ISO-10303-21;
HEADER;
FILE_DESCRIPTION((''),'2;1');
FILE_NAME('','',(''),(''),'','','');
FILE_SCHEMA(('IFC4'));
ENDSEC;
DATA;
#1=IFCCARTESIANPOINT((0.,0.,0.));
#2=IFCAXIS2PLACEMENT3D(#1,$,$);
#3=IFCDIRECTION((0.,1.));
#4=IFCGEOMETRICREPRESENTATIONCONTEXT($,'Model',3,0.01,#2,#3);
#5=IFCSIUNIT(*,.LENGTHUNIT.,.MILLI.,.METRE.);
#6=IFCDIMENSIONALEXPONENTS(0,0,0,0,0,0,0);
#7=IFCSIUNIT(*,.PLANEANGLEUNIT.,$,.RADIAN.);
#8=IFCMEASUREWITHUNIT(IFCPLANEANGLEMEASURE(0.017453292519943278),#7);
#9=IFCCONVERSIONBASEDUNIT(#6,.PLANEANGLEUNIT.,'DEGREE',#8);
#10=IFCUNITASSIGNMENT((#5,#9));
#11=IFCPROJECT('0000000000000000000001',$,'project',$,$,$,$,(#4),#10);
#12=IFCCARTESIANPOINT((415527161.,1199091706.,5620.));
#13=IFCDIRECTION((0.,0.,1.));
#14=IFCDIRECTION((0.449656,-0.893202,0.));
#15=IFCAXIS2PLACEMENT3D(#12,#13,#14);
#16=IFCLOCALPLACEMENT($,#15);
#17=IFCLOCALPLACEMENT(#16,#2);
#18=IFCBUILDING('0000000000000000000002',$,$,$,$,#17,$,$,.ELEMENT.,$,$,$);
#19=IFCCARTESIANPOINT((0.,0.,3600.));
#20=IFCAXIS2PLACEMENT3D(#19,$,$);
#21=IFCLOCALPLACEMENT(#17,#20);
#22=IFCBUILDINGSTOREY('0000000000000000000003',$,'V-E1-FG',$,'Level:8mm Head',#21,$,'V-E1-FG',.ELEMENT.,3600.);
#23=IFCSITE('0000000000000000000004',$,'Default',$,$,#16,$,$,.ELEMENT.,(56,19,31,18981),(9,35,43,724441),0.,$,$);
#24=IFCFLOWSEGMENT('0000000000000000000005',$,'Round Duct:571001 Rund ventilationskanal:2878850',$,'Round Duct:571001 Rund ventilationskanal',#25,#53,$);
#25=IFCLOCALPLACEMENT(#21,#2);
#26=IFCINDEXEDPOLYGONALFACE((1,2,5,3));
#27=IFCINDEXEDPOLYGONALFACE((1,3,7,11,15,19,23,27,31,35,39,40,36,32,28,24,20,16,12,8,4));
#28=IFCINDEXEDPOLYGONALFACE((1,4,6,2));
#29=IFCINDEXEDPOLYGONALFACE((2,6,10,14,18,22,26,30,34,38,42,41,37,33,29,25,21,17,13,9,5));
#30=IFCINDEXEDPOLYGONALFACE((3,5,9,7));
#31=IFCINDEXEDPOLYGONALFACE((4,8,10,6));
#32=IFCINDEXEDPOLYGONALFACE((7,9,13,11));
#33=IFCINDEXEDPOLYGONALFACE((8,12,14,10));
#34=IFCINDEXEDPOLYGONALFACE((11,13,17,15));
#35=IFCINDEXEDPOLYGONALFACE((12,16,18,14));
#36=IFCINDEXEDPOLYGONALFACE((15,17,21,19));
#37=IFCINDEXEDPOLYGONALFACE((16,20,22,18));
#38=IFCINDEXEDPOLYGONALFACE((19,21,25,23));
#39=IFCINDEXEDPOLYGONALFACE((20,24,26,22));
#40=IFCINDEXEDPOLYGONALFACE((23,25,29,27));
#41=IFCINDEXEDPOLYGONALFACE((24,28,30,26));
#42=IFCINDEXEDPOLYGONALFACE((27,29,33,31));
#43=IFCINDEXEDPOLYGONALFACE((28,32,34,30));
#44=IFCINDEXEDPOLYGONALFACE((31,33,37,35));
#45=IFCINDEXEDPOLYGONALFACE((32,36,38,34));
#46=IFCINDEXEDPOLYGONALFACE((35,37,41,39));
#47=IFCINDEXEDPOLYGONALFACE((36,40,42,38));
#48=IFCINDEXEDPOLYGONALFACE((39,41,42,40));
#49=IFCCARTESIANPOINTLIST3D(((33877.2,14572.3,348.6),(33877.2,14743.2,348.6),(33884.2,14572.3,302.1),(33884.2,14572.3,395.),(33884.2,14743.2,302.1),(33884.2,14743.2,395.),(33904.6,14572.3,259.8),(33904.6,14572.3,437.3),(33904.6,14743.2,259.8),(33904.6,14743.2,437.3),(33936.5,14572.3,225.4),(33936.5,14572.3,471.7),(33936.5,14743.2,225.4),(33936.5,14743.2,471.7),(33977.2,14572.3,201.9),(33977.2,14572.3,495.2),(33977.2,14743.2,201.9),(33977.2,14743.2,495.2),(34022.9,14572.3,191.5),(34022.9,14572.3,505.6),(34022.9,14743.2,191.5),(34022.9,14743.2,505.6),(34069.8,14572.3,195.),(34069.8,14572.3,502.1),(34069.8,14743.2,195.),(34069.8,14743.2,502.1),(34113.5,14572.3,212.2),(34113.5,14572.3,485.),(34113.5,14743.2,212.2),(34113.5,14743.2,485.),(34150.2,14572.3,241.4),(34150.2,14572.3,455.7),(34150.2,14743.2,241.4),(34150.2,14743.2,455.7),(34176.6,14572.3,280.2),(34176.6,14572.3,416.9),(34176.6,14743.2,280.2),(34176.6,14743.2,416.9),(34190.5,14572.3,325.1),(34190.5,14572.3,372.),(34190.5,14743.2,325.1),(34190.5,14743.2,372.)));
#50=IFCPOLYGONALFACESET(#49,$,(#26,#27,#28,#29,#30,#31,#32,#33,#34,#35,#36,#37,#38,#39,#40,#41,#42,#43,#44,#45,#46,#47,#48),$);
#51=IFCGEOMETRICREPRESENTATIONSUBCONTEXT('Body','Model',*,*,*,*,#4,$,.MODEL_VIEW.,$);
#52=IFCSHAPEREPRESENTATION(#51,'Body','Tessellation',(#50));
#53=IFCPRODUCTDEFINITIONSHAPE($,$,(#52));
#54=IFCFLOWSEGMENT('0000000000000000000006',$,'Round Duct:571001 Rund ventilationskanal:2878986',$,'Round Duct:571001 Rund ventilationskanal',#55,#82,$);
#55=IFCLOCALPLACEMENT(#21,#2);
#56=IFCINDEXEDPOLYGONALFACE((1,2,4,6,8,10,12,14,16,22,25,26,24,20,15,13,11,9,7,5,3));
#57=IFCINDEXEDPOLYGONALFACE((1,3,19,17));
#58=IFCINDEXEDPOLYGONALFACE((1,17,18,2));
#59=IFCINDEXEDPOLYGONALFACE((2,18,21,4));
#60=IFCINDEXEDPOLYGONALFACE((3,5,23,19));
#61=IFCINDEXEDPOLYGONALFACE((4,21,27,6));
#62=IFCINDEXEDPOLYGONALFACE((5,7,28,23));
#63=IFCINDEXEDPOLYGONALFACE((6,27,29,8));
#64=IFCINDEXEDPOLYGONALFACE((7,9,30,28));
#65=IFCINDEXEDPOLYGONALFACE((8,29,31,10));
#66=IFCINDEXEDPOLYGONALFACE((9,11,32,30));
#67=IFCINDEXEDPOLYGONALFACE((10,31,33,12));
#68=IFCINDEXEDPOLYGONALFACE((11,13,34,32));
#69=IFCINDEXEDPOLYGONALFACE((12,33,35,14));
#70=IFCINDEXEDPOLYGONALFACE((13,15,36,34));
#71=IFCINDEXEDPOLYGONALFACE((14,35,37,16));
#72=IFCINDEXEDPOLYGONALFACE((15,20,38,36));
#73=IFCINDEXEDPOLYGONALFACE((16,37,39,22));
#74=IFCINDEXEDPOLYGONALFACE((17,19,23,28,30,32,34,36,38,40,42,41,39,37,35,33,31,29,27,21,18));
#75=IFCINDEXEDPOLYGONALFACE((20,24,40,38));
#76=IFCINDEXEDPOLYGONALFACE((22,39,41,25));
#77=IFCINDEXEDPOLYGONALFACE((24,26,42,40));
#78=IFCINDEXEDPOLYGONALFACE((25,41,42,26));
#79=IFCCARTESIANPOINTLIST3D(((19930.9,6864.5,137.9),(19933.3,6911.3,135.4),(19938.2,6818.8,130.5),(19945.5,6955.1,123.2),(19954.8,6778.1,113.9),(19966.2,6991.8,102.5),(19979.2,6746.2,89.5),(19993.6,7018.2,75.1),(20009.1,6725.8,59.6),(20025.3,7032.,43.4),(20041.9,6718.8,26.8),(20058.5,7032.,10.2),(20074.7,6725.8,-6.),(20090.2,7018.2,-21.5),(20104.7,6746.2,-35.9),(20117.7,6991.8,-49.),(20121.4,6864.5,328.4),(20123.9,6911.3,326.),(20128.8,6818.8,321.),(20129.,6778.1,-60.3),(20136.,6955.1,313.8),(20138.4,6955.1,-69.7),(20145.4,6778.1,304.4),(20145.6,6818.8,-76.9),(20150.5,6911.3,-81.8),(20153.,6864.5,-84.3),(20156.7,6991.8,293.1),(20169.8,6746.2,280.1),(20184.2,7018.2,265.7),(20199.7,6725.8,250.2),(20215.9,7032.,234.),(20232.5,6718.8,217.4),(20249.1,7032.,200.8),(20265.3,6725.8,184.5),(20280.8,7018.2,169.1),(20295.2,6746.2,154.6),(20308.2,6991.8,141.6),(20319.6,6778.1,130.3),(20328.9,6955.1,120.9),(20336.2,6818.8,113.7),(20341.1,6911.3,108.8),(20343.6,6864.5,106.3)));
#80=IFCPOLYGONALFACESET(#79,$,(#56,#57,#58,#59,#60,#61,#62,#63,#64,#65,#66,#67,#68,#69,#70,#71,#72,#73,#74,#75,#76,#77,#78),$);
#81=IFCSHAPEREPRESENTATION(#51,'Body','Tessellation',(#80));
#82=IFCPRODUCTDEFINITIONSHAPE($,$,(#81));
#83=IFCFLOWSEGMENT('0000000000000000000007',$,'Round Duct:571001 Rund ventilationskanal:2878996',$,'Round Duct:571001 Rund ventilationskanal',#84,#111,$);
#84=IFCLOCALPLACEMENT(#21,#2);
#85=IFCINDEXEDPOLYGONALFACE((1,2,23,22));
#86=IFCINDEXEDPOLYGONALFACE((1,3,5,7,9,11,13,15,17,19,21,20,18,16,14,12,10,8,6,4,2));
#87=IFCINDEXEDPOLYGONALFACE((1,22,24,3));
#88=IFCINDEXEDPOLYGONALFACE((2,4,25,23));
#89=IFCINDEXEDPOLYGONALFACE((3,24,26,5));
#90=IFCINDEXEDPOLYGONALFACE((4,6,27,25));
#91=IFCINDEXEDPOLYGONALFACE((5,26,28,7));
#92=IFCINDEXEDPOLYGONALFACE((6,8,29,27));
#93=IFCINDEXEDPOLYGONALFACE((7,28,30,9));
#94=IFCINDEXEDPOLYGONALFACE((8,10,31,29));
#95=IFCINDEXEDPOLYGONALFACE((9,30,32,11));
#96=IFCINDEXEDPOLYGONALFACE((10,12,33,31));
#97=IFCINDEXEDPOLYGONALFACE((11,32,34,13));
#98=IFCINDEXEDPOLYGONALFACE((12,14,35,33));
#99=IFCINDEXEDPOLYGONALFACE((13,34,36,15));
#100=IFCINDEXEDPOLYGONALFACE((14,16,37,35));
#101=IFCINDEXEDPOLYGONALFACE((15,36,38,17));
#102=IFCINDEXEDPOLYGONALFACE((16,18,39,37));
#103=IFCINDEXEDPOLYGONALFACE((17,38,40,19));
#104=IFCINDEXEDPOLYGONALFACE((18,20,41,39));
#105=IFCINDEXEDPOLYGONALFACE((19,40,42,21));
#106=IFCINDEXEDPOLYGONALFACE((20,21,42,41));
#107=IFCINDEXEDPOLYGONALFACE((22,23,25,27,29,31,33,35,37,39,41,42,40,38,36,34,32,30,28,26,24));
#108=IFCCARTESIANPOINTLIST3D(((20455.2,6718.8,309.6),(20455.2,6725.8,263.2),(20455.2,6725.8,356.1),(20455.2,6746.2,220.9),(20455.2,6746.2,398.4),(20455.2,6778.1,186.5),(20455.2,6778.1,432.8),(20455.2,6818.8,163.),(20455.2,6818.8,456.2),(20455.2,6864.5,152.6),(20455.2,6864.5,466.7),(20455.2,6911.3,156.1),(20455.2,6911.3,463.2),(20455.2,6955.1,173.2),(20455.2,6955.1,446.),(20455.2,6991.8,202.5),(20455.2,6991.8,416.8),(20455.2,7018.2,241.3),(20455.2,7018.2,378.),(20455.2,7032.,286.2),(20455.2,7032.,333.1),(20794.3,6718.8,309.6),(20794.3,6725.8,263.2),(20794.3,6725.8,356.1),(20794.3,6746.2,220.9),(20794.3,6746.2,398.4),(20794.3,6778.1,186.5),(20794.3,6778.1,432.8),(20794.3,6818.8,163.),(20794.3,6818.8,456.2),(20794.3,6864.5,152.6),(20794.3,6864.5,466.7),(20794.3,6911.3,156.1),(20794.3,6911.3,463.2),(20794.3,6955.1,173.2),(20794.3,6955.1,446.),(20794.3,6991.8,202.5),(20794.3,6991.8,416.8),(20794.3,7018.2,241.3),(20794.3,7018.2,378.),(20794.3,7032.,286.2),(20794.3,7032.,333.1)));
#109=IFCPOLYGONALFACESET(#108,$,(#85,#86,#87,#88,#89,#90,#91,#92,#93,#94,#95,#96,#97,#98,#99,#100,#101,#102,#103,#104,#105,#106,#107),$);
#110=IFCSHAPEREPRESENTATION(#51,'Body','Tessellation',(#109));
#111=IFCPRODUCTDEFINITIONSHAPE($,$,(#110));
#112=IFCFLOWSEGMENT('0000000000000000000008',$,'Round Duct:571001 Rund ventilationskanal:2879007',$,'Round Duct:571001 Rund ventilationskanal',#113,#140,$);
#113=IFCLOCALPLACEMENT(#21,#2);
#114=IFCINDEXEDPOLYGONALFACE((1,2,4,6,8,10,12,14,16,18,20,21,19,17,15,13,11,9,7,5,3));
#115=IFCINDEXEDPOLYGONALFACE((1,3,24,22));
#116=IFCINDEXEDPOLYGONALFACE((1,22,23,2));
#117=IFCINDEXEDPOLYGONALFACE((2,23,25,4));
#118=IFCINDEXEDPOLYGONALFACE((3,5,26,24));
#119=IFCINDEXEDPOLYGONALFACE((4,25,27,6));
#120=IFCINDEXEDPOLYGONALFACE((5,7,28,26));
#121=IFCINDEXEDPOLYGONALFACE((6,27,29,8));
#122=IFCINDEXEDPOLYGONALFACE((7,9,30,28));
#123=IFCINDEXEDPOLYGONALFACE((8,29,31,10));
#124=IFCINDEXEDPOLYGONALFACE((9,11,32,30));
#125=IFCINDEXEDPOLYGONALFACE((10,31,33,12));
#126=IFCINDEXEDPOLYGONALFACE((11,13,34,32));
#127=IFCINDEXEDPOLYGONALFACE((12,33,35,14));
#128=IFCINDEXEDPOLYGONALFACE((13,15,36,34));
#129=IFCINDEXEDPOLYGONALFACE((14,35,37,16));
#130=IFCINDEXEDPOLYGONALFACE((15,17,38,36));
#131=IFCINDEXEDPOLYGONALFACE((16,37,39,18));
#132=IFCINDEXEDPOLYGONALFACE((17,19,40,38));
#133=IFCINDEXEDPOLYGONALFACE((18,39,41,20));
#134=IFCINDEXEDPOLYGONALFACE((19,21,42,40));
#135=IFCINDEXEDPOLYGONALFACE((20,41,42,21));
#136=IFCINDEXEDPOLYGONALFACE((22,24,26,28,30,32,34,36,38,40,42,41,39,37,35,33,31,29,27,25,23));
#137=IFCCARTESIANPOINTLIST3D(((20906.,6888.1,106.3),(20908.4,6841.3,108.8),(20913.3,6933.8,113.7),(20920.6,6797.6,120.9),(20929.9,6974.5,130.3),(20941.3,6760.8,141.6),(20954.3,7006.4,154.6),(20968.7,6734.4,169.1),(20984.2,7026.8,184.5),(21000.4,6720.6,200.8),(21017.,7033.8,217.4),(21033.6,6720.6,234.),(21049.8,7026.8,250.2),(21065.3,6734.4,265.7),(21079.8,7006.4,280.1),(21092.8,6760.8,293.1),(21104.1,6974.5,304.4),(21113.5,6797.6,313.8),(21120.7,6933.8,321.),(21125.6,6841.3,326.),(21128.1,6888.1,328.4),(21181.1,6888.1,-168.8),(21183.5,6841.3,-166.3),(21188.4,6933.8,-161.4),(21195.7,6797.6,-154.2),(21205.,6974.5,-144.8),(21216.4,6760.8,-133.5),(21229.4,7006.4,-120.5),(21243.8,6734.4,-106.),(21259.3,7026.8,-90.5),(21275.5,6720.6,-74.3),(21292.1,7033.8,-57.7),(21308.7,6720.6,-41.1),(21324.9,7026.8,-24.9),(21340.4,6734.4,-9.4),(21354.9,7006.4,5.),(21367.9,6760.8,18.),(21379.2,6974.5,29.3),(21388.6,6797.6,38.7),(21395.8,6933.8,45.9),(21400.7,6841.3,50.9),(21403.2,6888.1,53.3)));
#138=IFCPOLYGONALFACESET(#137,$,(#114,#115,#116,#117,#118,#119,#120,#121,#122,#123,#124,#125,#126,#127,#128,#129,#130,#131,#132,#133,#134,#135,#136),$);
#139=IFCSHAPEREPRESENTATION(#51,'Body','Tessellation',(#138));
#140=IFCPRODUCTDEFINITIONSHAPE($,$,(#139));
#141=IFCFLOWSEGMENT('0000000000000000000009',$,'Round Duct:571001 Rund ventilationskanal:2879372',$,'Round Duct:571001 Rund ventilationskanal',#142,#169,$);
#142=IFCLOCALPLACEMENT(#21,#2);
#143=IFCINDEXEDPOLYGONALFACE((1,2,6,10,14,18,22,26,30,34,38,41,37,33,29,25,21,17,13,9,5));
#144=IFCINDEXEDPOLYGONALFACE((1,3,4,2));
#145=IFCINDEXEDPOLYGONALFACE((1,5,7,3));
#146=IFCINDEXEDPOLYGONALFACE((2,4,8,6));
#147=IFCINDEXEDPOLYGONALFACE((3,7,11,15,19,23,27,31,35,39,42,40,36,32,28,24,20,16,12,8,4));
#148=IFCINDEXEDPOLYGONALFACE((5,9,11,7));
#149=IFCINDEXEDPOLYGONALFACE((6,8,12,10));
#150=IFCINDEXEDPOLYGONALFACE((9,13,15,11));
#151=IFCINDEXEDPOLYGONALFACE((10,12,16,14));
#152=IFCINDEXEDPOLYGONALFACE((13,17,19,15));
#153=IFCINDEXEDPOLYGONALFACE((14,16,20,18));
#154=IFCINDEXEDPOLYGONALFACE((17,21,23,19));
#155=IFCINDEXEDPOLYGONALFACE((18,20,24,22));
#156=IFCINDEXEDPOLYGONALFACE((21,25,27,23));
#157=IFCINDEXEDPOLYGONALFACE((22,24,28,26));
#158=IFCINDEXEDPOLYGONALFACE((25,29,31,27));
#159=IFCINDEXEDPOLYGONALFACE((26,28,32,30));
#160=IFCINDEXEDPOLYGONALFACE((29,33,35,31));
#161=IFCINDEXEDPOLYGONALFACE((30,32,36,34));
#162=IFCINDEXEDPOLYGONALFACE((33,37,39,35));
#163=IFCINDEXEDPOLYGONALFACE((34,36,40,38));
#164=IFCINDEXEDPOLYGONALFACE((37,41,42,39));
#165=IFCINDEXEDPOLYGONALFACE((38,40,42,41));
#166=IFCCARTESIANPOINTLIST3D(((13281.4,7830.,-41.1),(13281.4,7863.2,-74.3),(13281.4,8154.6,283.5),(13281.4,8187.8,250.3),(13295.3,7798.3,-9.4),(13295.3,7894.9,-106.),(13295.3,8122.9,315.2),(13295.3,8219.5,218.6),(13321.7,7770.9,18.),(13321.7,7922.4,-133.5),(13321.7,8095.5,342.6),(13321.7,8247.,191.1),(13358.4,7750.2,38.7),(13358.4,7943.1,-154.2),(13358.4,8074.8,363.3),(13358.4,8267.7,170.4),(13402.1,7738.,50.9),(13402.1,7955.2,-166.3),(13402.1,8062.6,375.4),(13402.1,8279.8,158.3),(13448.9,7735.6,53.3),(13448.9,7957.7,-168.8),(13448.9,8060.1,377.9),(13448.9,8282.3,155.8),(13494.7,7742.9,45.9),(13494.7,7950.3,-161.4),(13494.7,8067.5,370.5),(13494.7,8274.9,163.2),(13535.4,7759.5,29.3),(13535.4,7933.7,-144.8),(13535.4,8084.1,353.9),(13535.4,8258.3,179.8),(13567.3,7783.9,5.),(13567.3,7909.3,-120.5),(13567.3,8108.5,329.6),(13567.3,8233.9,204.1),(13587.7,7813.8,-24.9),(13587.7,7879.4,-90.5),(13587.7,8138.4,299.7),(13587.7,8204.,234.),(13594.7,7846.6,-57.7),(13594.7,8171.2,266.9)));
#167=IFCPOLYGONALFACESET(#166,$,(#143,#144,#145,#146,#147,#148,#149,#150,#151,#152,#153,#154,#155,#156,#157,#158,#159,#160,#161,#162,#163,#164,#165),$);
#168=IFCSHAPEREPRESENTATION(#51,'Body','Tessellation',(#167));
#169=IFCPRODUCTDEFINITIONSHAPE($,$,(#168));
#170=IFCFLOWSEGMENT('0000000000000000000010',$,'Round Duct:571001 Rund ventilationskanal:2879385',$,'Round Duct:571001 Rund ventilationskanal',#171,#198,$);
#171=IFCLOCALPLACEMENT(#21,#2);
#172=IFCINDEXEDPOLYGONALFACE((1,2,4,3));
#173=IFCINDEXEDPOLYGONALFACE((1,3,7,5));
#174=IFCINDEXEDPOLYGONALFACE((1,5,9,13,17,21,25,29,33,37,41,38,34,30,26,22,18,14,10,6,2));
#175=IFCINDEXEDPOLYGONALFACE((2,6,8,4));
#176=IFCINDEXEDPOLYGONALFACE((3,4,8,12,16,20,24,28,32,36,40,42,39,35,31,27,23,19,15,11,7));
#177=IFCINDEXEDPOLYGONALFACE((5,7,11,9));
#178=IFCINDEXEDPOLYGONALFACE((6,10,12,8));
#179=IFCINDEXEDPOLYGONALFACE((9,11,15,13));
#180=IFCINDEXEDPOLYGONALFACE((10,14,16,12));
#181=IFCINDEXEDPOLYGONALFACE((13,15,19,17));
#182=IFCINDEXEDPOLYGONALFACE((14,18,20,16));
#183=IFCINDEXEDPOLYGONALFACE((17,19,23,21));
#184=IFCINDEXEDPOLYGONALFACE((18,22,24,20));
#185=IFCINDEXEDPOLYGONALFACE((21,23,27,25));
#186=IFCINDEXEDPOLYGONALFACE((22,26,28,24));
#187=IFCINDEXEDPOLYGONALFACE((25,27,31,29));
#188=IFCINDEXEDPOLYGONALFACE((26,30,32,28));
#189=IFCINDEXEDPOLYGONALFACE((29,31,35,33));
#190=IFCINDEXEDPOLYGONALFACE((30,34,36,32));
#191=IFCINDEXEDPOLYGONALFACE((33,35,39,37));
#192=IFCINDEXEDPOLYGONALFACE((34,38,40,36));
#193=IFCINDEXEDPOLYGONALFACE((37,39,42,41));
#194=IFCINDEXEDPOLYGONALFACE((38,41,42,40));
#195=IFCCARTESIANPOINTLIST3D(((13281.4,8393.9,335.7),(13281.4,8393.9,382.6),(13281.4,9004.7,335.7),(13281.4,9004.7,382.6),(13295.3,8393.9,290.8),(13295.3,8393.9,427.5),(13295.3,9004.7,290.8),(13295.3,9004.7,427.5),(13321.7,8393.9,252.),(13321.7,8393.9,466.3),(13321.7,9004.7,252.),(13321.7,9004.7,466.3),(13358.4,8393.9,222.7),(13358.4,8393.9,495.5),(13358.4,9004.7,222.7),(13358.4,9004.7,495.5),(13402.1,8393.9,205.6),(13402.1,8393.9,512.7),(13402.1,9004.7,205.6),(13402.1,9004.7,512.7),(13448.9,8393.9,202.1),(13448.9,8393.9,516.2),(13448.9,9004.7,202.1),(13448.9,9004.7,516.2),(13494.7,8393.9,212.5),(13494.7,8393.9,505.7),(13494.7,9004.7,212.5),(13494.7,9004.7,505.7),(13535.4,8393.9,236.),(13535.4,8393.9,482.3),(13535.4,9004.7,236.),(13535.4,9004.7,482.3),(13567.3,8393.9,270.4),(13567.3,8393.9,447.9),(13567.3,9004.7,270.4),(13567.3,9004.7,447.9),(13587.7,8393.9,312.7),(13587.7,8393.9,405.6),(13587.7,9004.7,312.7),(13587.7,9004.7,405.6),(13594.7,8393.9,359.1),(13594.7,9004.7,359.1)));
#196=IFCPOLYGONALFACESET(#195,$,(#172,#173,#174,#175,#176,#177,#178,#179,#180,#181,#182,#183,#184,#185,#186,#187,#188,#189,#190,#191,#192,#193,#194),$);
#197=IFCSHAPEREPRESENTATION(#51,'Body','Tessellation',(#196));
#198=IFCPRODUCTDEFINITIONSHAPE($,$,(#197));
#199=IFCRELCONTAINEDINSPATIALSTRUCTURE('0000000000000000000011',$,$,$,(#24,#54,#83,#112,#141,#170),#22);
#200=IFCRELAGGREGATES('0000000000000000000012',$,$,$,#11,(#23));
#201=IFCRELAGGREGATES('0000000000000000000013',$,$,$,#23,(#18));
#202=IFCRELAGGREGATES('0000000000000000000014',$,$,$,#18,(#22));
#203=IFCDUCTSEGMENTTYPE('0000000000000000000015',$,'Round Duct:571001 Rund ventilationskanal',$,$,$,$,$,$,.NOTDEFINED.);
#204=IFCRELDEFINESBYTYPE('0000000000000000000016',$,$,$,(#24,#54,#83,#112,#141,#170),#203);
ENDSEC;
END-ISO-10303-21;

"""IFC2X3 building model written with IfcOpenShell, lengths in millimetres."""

from ifc_helpers import new_model, entity, si_unit, converted_unit, direction, frame, frame_2d, origin, origin_2d_with_axis, place, context, subcontext, project, spatial, circle, extrude, type_object, element, save


model = new_model("IFC2X3")

# Units and contexts
model_context = context("Model", 3, precision=0.01, world=origin(), true_north=direction((0.0, 1.0)))
body_context = subcontext(model_context, "Body", "Model", "MODEL_VIEW")
ifc_project = project(units=[si_unit("LENGTHUNIT", "METRE", prefix="MILLI"), converted_unit("PLANEANGLEUNIT", "DEGREE", entity("IfcPlaneAngleMeasure", 0.017453292519943278), si_unit("PLANEANGLEUNIT", "RADIAN"), dimensions=[0, 0, 0, 0, 0, 0, 0])], contexts=[model_context])

# Site, building, storey
site_placement = place(None, frame((415527161.0, 1199091706.0, 5620.0), z_axis=(0.0, 0.0, 1.0), x_axis=(0.449656, -0.893202, 0.0)))
site = spatial("IfcSite", under=ifc_project, at=site_placement, Name="Default", CompositionType="ELEMENT", RefLatitude=(56, 19, 31, 18981), RefLongitude=(9, 35, 43, 724441), RefElevation=0.0)
building_placement = place(site_placement, origin())
building = spatial("IfcBuilding", under=site, at=building_placement, CompositionType="ELEMENT")
storey_placement = place(building_placement, frame((0.0, 0.0, 3600.0)))
storey = spatial("IfcBuildingStorey", under=building, at=storey_placement, Name="V-E1-FG", ObjectType="Level:8mm Head", LongName="V-E1-FG", CompositionType="ELEMENT", Elevation=3600.0)

# Flow segments
duct_segment_type = type_object("IfcDuctSegmentType", Name="Round Duct:571001 Rund ventilationskanal", PredefinedType="NOTDEFINED")
flow_segment_1_placement = place(storey_placement, origin())
element("IfcFlowSegment", 1, at=flow_segment_1_placement, inside=storey, type_object=duct_segment_type, Name="Round Duct:571001 Rund ventilationskanal:2878850", ObjectType="Round Duct:571001 Rund ventilationskanal", context=body_context, shape_type="SweptSolid", body=[
    extrude(circle(Radius=157.5, at=origin_2d_with_axis()), frame((34034.7, 14572.3, 348.6), z_axis=(0.0, 1.0, 0.0), x_axis=(-1.0, 0.0, 0.0)), (0.0, 0.0, 1.0), 171.0),
])
flow_segment_2_placement = place(storey_placement, origin())
element("IfcFlowSegment", 2, at=flow_segment_2_placement, inside=storey, type_object=duct_segment_type, Name="Round Duct:571001 Rund ventilationskanal:2878986", ObjectType="Round Duct:571001 Rund ventilationskanal", context=body_context, shape_type="SweptSolid", body=[
    extrude(circle(Radius=157.5, at=frame_2d((0.0, 0.0), x_axis=(1.0, 0.0))), frame((20041.9, 6876.3, 26.8), z_axis=(0.707107, 0.0, 0.707107), x_axis=(0.0, -1.0, 0.0)), (0.0, 0.0, 1.0), 269.5),
])
flow_segment_3_placement = place(storey_placement, origin())
element("IfcFlowSegment", 3, at=flow_segment_3_placement, inside=storey, type_object=duct_segment_type, Name="Round Duct:571001 Rund ventilationskanal:2878996", ObjectType="Round Duct:571001 Rund ventilationskanal", context=body_context, shape_type="SweptSolid", body=[
    extrude(circle(Radius=157.5, at=frame_2d((0.0, 0.0), x_axis=(1.0, 0.0))), frame((20455.2, 6876.3, 309.6), z_axis=(1.0, 0.0, 0.0), x_axis=(0.0, -1.0, 0.0)), (0.0, 0.0, 1.0), 339.0),
])
flow_segment_4_placement = place(storey_placement, origin())
element("IfcFlowSegment", 4, at=flow_segment_4_placement, inside=storey, type_object=duct_segment_type, Name="Round Duct:571001 Rund ventilationskanal:2879007", ObjectType="Round Duct:571001 Rund ventilationskanal", context=body_context, shape_type="SweptSolid", body=[
    extrude(circle(Radius=157.5, at=frame_2d((0.0, 0.0), x_axis=(1.0, 0.0))), frame((21017.0, 6876.3, 217.4), z_axis=(0.707107, 0.0, -0.707107), x_axis=(0.0, 1.0, 0.0)), (0.0, 0.0, 1.0), 389.0),
])
flow_segment_5_placement = place(storey_placement, origin())
element("IfcFlowSegment", 5, at=flow_segment_5_placement, inside=storey, type_object=duct_segment_type, Name="Round Duct:571001 Rund ventilationskanal:2879372", ObjectType="Round Duct:571001 Rund ventilationskanal", context=body_context, shape_type="SweptSolid", body=[
    extrude(circle(Radius=157.5, at=frame_2d((0.0, 0.0), x_axis=(1.0, 0.0))), frame((13437.2, 7846.6, -57.7), z_axis=(0.0, 0.707107, 0.707107), x_axis=(1.0, 0.0, 0.0)), (0.0, 0.0, 1.0), 459.0),
])
flow_segment_6_placement = place(storey_placement, origin())
element("IfcFlowSegment", 6, at=flow_segment_6_placement, inside=storey, type_object=duct_segment_type, Name="Round Duct:571001 Rund ventilationskanal:2879385", ObjectType="Round Duct:571001 Rund ventilationskanal", context=body_context, shape_type="SweptSolid", body=[
    extrude(circle(Radius=157.5, at=frame_2d((0.0, 0.0), x_axis=(1.0, 0.0))), frame((13437.2, 8393.9, 359.1), z_axis=(0.0, 1.0, 0.0), x_axis=(1.0, 0.0, 0.0)), (0.0, 0.0, 1.0), 610.8),
])

save(model, "model.ifc")
